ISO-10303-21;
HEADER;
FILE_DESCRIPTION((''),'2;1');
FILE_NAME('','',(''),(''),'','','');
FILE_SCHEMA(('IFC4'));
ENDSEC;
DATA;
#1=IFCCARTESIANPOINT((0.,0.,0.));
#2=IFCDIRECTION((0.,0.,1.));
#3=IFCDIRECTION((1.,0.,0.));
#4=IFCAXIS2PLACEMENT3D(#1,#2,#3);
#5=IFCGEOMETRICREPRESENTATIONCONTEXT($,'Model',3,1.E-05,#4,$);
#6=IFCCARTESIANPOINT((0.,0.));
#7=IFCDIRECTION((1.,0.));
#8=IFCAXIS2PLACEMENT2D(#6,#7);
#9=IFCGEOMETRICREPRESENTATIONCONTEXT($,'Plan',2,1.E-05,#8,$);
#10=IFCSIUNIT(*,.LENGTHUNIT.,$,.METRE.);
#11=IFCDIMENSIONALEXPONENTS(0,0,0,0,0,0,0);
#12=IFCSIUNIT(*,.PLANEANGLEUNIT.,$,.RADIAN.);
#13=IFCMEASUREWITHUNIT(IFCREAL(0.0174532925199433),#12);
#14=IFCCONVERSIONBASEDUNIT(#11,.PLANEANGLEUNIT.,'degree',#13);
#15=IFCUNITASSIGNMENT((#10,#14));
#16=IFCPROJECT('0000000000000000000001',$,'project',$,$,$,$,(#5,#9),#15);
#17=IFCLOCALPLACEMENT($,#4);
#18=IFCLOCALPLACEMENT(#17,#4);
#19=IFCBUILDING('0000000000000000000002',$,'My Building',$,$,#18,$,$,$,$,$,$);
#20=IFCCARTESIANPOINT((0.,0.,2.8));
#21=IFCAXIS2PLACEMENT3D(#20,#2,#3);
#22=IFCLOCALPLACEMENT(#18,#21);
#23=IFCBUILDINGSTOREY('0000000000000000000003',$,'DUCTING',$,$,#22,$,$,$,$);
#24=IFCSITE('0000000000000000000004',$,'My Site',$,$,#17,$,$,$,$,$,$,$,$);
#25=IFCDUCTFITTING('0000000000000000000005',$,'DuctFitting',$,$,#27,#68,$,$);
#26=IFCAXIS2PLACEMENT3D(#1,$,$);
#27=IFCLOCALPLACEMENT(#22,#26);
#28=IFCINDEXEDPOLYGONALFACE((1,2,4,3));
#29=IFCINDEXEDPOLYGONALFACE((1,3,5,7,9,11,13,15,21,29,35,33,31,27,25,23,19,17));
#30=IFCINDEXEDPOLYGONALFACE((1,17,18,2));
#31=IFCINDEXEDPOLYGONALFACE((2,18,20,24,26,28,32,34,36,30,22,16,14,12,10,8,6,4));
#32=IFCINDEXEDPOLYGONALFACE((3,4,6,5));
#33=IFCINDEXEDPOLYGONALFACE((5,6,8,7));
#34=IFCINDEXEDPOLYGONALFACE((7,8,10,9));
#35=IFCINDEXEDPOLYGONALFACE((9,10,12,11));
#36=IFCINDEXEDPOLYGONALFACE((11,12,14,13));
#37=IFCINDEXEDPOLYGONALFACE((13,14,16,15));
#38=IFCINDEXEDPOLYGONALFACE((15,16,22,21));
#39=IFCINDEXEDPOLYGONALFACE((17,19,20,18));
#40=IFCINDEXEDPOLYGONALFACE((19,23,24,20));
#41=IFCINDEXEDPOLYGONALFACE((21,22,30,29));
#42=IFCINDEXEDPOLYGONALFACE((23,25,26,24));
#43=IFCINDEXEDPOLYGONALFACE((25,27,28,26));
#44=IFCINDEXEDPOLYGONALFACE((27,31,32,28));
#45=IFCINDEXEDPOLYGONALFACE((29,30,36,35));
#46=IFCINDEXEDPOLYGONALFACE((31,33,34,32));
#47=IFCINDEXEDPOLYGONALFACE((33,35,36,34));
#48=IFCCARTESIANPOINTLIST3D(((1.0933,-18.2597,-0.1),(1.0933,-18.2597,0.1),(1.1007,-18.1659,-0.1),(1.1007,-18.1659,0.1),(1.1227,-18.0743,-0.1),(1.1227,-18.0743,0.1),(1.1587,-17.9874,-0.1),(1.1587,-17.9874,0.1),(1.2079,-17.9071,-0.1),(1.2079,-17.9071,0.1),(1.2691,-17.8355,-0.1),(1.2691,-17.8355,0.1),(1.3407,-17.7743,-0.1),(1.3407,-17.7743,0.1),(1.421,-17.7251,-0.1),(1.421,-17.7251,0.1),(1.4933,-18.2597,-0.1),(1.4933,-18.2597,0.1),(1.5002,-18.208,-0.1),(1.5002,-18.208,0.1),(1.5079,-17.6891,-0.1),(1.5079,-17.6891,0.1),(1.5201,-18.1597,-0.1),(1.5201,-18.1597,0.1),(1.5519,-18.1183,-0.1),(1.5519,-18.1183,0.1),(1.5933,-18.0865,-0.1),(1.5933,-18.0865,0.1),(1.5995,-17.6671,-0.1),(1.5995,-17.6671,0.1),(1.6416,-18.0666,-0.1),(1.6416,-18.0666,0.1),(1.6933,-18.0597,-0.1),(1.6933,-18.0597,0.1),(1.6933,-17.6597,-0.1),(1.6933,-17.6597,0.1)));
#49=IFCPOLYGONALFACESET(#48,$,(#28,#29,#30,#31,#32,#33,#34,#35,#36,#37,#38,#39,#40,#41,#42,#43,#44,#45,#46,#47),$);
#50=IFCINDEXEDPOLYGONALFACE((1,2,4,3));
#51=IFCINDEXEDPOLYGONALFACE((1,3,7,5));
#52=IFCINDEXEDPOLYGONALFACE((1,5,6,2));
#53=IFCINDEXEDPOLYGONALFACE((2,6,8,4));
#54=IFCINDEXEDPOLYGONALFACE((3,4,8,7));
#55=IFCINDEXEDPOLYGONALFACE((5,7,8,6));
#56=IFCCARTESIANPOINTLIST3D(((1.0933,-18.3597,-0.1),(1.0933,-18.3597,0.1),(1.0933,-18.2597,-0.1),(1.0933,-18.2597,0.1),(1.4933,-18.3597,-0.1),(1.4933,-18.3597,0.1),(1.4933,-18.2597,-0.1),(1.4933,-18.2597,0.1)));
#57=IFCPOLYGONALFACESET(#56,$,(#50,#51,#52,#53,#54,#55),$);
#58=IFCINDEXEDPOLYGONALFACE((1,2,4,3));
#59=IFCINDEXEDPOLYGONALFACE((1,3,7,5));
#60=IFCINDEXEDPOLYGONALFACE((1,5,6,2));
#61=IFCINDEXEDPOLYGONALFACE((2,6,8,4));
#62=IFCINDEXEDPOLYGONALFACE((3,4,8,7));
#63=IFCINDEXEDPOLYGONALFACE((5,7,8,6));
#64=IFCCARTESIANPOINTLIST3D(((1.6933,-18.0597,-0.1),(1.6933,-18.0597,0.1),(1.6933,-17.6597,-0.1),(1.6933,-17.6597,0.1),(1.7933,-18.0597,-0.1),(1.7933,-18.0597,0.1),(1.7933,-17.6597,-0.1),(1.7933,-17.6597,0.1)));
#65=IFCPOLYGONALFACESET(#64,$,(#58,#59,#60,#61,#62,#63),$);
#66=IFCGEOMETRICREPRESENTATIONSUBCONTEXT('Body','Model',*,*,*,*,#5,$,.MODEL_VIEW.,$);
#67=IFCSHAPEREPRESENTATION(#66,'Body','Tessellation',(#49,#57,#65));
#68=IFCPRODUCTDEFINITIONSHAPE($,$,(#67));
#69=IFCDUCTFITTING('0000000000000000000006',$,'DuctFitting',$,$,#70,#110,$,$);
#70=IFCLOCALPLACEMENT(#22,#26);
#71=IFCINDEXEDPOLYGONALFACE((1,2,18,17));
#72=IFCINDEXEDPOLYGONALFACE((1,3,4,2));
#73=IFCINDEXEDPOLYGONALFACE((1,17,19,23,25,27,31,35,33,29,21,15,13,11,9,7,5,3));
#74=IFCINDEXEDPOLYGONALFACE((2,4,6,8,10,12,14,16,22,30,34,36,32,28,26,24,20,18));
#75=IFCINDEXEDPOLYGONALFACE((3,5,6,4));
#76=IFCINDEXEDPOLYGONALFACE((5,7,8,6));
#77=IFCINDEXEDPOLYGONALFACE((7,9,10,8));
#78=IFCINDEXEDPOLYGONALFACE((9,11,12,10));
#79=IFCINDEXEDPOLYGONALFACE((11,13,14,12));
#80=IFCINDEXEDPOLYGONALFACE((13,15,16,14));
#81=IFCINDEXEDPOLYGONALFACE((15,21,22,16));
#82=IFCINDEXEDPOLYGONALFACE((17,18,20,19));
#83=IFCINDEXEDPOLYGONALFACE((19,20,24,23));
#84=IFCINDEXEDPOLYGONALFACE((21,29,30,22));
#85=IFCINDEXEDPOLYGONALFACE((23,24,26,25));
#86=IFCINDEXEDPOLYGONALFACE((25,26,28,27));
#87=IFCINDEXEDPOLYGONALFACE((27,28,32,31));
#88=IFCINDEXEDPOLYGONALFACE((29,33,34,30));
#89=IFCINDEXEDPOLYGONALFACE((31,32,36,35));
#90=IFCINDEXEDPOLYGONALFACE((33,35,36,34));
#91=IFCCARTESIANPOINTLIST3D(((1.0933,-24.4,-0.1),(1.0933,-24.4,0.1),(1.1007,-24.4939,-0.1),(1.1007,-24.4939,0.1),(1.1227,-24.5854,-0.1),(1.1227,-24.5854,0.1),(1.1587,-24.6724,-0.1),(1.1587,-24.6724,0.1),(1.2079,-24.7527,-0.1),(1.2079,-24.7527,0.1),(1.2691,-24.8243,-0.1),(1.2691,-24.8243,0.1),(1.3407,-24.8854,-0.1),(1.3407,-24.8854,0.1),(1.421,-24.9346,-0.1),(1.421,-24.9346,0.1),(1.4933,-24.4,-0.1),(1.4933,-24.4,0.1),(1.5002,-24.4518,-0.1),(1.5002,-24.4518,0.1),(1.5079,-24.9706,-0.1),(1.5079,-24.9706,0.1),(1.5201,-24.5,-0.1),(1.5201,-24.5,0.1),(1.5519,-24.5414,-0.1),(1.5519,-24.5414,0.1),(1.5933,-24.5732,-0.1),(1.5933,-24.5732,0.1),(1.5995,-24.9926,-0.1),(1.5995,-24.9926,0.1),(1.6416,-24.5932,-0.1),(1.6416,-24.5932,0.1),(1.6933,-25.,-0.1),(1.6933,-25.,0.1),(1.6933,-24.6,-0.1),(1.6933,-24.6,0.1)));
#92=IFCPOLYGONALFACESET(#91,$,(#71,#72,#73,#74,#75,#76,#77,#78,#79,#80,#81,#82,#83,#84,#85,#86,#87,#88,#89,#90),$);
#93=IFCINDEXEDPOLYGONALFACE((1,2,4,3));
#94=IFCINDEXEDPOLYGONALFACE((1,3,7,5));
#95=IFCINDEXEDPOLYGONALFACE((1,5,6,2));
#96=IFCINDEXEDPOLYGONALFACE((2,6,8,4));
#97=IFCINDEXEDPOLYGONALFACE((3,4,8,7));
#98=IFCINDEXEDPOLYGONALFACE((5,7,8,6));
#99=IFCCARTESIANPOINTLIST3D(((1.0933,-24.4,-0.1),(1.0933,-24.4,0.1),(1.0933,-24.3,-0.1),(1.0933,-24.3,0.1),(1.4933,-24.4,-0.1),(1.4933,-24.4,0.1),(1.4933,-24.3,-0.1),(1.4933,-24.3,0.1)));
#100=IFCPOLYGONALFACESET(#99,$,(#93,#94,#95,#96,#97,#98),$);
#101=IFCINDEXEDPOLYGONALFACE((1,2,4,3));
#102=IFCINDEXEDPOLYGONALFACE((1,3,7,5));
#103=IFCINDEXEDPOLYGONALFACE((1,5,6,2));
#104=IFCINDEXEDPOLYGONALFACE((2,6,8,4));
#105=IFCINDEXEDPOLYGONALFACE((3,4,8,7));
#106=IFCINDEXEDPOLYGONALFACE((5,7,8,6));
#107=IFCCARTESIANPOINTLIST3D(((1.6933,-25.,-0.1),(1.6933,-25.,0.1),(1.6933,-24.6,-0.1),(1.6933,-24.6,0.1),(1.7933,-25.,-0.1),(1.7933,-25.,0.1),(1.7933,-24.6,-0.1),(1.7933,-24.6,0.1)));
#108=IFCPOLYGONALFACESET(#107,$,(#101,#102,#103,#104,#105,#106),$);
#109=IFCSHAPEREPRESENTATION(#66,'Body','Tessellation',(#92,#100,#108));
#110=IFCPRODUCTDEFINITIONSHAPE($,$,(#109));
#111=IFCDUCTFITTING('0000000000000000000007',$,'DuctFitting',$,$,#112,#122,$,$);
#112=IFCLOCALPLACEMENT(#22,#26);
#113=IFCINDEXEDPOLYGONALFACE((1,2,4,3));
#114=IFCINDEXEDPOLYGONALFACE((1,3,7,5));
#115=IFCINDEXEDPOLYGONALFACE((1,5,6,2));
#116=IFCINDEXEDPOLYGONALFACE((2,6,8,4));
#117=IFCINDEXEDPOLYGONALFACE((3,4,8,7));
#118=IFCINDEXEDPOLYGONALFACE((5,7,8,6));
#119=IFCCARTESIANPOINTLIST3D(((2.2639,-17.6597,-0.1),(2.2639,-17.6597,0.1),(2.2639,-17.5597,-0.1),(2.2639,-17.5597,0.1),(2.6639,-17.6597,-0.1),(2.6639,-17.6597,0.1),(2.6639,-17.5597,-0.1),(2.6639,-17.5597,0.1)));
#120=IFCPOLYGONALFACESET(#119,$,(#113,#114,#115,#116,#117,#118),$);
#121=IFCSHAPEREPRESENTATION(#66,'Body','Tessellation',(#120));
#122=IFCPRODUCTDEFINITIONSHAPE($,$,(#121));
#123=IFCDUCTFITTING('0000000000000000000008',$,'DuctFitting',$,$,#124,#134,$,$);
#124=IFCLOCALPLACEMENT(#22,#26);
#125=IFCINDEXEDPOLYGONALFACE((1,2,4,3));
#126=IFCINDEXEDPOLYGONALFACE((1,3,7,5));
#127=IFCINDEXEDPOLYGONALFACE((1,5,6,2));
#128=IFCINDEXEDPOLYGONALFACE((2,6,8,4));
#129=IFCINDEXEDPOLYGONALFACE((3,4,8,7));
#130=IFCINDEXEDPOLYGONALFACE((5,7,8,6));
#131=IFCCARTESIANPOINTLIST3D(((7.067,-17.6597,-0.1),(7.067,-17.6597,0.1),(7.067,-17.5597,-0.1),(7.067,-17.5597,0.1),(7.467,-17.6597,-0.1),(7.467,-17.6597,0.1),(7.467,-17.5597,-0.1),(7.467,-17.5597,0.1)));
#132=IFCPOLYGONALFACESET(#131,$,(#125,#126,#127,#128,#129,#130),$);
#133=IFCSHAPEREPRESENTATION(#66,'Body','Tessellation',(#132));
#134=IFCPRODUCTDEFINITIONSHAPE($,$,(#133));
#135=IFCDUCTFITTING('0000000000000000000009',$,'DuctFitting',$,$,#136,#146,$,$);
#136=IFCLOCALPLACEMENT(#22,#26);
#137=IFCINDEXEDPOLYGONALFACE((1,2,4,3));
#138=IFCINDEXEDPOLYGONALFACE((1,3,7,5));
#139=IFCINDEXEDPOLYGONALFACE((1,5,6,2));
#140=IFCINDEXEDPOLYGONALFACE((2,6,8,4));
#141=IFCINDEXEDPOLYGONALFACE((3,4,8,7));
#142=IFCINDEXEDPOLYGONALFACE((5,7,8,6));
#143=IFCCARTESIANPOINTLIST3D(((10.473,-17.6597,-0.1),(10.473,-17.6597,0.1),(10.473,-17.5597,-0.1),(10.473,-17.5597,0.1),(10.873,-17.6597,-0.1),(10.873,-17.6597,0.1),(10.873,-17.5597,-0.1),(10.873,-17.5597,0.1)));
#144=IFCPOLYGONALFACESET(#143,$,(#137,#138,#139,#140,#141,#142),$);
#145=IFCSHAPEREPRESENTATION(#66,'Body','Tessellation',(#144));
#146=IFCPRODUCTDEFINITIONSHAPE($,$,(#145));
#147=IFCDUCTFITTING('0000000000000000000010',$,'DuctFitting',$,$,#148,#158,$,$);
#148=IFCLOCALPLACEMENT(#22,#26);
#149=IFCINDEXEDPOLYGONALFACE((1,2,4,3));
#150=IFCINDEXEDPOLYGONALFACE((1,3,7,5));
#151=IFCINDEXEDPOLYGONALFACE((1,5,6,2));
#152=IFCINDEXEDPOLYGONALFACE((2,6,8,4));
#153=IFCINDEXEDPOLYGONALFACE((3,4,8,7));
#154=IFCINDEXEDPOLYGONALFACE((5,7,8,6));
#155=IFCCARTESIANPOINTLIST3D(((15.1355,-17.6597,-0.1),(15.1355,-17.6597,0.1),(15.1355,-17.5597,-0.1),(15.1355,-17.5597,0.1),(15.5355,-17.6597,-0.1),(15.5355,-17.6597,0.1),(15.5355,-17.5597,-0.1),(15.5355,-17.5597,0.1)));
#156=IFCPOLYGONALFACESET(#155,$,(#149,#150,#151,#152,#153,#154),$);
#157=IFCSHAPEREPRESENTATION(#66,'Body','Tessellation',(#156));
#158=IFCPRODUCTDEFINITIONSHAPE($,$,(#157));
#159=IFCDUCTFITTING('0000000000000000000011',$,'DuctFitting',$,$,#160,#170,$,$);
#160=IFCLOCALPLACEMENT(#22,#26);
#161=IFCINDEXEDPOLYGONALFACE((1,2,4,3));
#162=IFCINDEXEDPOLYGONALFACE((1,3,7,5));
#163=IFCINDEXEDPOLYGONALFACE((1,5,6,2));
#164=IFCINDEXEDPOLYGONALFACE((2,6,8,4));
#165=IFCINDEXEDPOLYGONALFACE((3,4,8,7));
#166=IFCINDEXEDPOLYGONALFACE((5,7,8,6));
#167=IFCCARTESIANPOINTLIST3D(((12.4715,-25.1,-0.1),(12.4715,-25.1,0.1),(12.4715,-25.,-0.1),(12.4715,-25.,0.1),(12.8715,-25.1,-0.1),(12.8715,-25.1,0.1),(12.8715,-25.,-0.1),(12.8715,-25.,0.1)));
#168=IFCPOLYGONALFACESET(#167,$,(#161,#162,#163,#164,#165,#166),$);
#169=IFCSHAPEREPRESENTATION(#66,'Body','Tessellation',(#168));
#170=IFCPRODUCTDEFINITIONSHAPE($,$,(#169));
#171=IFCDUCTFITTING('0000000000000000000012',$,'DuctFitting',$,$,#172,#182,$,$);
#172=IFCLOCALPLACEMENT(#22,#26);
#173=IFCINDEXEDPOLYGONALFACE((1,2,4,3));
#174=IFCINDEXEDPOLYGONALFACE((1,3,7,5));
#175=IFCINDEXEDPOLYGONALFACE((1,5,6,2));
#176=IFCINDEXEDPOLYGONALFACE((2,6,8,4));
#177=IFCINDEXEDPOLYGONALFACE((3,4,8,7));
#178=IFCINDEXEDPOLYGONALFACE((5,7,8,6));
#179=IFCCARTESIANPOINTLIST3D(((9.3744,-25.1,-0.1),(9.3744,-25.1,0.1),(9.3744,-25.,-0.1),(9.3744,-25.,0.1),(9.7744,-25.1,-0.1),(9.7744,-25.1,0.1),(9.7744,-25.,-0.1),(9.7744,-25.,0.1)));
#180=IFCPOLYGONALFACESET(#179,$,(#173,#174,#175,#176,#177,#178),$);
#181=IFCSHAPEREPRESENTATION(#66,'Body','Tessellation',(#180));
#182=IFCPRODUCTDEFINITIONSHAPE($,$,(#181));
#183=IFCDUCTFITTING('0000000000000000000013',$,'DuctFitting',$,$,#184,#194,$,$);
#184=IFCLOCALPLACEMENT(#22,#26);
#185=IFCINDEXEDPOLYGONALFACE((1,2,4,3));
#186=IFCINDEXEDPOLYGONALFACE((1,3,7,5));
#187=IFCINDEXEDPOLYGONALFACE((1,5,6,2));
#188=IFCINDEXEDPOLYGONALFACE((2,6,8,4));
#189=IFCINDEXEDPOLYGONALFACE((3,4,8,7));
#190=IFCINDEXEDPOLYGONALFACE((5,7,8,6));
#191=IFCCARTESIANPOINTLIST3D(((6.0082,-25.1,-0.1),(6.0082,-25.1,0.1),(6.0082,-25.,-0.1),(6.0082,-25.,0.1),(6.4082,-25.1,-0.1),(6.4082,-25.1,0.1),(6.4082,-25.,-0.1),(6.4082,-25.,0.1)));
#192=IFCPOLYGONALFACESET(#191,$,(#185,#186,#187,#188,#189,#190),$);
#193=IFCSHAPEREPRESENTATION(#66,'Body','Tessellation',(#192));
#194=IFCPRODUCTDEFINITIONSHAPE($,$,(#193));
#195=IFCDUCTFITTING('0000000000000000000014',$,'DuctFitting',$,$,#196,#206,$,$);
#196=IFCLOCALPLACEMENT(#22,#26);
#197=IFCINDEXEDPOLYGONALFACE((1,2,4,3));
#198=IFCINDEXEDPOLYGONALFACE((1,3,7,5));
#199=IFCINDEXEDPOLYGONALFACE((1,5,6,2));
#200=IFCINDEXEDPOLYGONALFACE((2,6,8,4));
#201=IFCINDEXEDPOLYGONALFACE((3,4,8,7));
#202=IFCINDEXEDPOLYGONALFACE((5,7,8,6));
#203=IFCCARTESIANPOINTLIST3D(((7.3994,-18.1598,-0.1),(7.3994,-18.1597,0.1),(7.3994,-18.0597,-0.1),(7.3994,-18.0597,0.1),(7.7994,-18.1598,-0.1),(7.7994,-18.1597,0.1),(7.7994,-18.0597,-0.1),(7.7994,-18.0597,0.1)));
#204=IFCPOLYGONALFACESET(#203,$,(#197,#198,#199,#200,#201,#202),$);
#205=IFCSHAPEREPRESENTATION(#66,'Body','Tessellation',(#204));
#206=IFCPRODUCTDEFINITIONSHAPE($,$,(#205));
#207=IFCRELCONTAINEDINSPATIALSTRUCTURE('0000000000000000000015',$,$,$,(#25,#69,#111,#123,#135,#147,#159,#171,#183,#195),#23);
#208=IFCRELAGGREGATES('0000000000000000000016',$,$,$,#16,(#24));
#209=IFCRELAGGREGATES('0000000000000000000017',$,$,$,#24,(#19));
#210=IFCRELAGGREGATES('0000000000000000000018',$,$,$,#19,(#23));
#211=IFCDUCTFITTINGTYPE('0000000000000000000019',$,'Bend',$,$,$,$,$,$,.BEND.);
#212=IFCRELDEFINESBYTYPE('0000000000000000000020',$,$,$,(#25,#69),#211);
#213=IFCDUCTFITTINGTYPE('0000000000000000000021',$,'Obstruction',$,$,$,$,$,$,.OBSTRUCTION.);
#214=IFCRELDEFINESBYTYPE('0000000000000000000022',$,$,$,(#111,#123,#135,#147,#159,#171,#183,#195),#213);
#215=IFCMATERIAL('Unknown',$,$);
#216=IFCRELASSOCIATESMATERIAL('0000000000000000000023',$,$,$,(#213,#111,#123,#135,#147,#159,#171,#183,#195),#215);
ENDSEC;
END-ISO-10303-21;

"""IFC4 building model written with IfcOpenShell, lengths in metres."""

from ifc_helpers import new_model, entity, si_unit, converted_unit, frame, origin_with_axes, origin_2d_with_axis, place, context, subcontext, project, spatial, line, arc, indexed_curve, rectangle, outline, extrude, source, transform, mapped, material, material_profile, profile_set, profile_usage, type_object, type_shapes, element, save


model = new_model("IFC4")

# Units and contexts
model_context = context("Model", 3, precision=1e-05, world=origin_with_axes())
plan_context = context("Plan", 2, precision=1e-05, world=origin_2d_with_axis())
body_context = subcontext(model_context, "Body", "Model", "MODEL_VIEW")
ifc_project = project(units=[si_unit("LENGTHUNIT", "METRE"), converted_unit("PLANEANGLEUNIT", "degree", entity("IfcReal", 0.0174532925199433), si_unit("PLANEANGLEUNIT", "RADIAN"), dimensions=[0, 0, 0, 0, 0, 0, 0])], contexts=[model_context, plan_context])

# Site, building, storey
site_placement = place(None, origin_with_axes())
site = spatial("IfcSite", under=ifc_project, at=site_placement, Name="My Site")
building_placement = place(site_placement, origin_with_axes())
building = spatial("IfcBuilding", under=site, at=building_placement, Name="My Building")
storey_placement = place(building_placement, frame((0.0, 0.0, 2.8), z_axis=(0.0, 0.0, 1.0), x_axis=(1.0, 0.0, 0.0)))
storey = spatial("IfcBuildingStorey", under=building, at=storey_placement, Name="DUCTING")

# Shared definitions
ifc_material = material(Name="Unknown")

# Duct fittings
duct_fitting_type_1 = type_object("IfcDuctFittingType", Name="Bend", PredefinedType="BEND")
shared_shape = source(origin_with_axes(), body_context, "Body", "SweptSolid", [
    extrude(outline(indexed_curve([(0.2, 0.0), (0.2586, -0.1414), (0.4, -0.2), (0.4, -0.6), (-0.0243, -0.4243), (-0.2, 0.0)], segments=[arc(1, 2, 3), line(3, 4), arc(4, 5, 6), line(6, 1)])), frame((0.0, -0.1, -0.1), z_axis=(0.0, -1.0, 0.0), x_axis=(1.0, 0.0, 0.0)), (0.0, 0.0, -1.0), 0.2),
    extrude(rectangle(XDim=0.4, YDim=0.2), origin_with_axes(), (0.0, 0.0, -1.0), 0.1),
    extrude(rectangle(XDim=0.4, YDim=0.2), frame((0.4, 0.0, -0.5), z_axis=(1.0, 0.0, 0.0), x_axis=(0.0, 0.0, 1.0)), (0.0, 0.0, 1.0), 0.1),
])
type_shapes(duct_fitting_type_1, [shared_shape])
for number, where, z_axis, x_axis, name in (
    (1, (1.2933, -18.3597, 0.0), (0.0, -1.0, 0.0), (1.0, 0.0, 0.0), "DuctFitting"),
    (2, (1.2933, -24.3, 0.0), (0.0, 1.0, 0.0), (1.0, 0.0, 0.0), "DuctFitting"),
):
    element("IfcDuctFitting", number, at=place(storey_placement, frame(where, z_axis=z_axis, x_axis=x_axis)), inside=storey, type_object=duct_fitting_type_1, Name=name, context=body_context, shape_type="MappedRepresentation", body=[
        mapped(shared_shape, transform((0.0, 0.0, 0.0), x_axis=(1.0, 0.0, 0.0), y_axis=(0.0, 1.0, 0.0), z_axis=(0.0, 0.0, 1.0), scale=1.0)),
    ])
ifc_material_profile_1 = material_profile(ifc_material, rectangle(XDim=0.4, YDim=0.2))
ifc_profile_set_1 = profile_set([ifc_material_profile_1])
ifc_profile_usage_1 = profile_usage(ifc_profile_set_1, cardinal=5)
duct_fitting_type_2 = type_object("IfcDuctFittingType", Name="Obstruction", PredefinedType="OBSTRUCTION", material=ifc_profile_set_1)
duct_fitting_1_placement = place(storey_placement, frame((2.4639, -17.5597, 0.0), z_axis=(0.0, -1.0, 0.0), x_axis=(1.0, 0.0, 0.0)))
element("IfcDuctFitting", 3, at=duct_fitting_1_placement, inside=storey, type_object=duct_fitting_type_2, material=ifc_profile_usage_1, Name="DuctFitting", context=body_context, shape_type="SweptSolid", body=[
    extrude(rectangle(XDim=0.4, YDim=0.2), origin_with_axes(), (0.0, 0.0, 1.0), 0.1),
])
ifc_profile_usage_2 = profile_usage(ifc_profile_set_1, cardinal=5)
duct_fitting_2_placement = place(storey_placement, frame((7.267, -17.5597, 0.0), z_axis=(0.0, -1.0, 0.0), x_axis=(1.0, 0.0, 0.0)))
element("IfcDuctFitting", 4, at=duct_fitting_2_placement, inside=storey, type_object=duct_fitting_type_2, material=ifc_profile_usage_2, Name="DuctFitting", context=body_context, shape_type="SweptSolid", body=[
    extrude(rectangle(XDim=0.4, YDim=0.2), origin_with_axes(), (0.0, 0.0, 1.0), 0.1),
])
ifc_profile_usage_3 = profile_usage(ifc_profile_set_1, cardinal=5)
duct_fitting_3_placement = place(storey_placement, frame((10.673, -17.5597, 0.0), z_axis=(0.0, -1.0, 0.0), x_axis=(1.0, 0.0, 0.0)))
element("IfcDuctFitting", 5, at=duct_fitting_3_placement, inside=storey, type_object=duct_fitting_type_2, material=ifc_profile_usage_3, Name="DuctFitting", context=body_context, shape_type="SweptSolid", body=[
    extrude(rectangle(XDim=0.4, YDim=0.2), origin_with_axes(), (0.0, 0.0, 1.0), 0.1),
])
ifc_profile_usage_4 = profile_usage(ifc_profile_set_1, cardinal=5)
duct_fitting_4_placement = place(storey_placement, frame((15.3355, -17.5597, 0.0), z_axis=(0.0, -1.0, 0.0), x_axis=(1.0, 0.0, 0.0)))
element("IfcDuctFitting", 6, at=duct_fitting_4_placement, inside=storey, type_object=duct_fitting_type_2, material=ifc_profile_usage_4, Name="DuctFitting", context=body_context, shape_type="SweptSolid", body=[
    extrude(rectangle(XDim=0.4, YDim=0.2), origin_with_axes(), (0.0, 0.0, 1.0), 0.1),
])
ifc_profile_usage_5 = profile_usage(ifc_profile_set_1, cardinal=5)
duct_fitting_5_placement = place(storey_placement, frame((12.6715, -25.0, 0.0), z_axis=(0.0, -1.0, 0.0), x_axis=(1.0, 0.0, 0.0)))
element("IfcDuctFitting", 7, at=duct_fitting_5_placement, inside=storey, type_object=duct_fitting_type_2, material=ifc_profile_usage_5, Name="DuctFitting", context=body_context, shape_type="SweptSolid", body=[
    extrude(rectangle(XDim=0.4, YDim=0.2), origin_with_axes(), (0.0, 0.0, 1.0), 0.1),
])
ifc_profile_usage_6 = profile_usage(ifc_profile_set_1, cardinal=5)
duct_fitting_6_placement = place(storey_placement, frame((9.5744, -25.0, 0.0), z_axis=(0.0, -1.0, 0.0), x_axis=(1.0, 0.0, 0.0)))
element("IfcDuctFitting", 8, at=duct_fitting_6_placement, inside=storey, type_object=duct_fitting_type_2, material=ifc_profile_usage_6, Name="DuctFitting", context=body_context, shape_type="SweptSolid", body=[
    extrude(rectangle(XDim=0.4, YDim=0.2), origin_with_axes(), (0.0, 0.0, 1.0), 0.1),
])
ifc_profile_usage_7 = profile_usage(ifc_profile_set_1, cardinal=5)
duct_fitting_7_placement = place(storey_placement, frame((6.2082, -25.0, 0.0), z_axis=(0.0, -1.0, 0.0), x_axis=(1.0, 0.0, 0.0)))
element("IfcDuctFitting", 9, at=duct_fitting_7_placement, inside=storey, type_object=duct_fitting_type_2, material=ifc_profile_usage_7, Name="DuctFitting", context=body_context, shape_type="SweptSolid", body=[
    extrude(rectangle(XDim=0.4, YDim=0.2), origin_with_axes(), (0.0, 0.0, 1.0), 0.1),
])
ifc_profile_usage_8 = profile_usage(ifc_profile_set_1, cardinal=5)
duct_fitting_8_placement = place(storey_placement, frame((7.5994, -18.0597, 0.0), z_axis=(0.0, -1.0, 0.0), x_axis=(1.0, 0.0, 0.0)))
element("IfcDuctFitting", 10, at=duct_fitting_8_placement, inside=storey, type_object=duct_fitting_type_2, material=ifc_profile_usage_8, Name="DuctFitting", context=body_context, shape_type="SweptSolid", body=[
    extrude(rectangle(XDim=0.4, YDim=0.2), origin_with_axes(), (0.0, 0.0, 1.0), 0.1),
])

save(model, "model.ifc")
